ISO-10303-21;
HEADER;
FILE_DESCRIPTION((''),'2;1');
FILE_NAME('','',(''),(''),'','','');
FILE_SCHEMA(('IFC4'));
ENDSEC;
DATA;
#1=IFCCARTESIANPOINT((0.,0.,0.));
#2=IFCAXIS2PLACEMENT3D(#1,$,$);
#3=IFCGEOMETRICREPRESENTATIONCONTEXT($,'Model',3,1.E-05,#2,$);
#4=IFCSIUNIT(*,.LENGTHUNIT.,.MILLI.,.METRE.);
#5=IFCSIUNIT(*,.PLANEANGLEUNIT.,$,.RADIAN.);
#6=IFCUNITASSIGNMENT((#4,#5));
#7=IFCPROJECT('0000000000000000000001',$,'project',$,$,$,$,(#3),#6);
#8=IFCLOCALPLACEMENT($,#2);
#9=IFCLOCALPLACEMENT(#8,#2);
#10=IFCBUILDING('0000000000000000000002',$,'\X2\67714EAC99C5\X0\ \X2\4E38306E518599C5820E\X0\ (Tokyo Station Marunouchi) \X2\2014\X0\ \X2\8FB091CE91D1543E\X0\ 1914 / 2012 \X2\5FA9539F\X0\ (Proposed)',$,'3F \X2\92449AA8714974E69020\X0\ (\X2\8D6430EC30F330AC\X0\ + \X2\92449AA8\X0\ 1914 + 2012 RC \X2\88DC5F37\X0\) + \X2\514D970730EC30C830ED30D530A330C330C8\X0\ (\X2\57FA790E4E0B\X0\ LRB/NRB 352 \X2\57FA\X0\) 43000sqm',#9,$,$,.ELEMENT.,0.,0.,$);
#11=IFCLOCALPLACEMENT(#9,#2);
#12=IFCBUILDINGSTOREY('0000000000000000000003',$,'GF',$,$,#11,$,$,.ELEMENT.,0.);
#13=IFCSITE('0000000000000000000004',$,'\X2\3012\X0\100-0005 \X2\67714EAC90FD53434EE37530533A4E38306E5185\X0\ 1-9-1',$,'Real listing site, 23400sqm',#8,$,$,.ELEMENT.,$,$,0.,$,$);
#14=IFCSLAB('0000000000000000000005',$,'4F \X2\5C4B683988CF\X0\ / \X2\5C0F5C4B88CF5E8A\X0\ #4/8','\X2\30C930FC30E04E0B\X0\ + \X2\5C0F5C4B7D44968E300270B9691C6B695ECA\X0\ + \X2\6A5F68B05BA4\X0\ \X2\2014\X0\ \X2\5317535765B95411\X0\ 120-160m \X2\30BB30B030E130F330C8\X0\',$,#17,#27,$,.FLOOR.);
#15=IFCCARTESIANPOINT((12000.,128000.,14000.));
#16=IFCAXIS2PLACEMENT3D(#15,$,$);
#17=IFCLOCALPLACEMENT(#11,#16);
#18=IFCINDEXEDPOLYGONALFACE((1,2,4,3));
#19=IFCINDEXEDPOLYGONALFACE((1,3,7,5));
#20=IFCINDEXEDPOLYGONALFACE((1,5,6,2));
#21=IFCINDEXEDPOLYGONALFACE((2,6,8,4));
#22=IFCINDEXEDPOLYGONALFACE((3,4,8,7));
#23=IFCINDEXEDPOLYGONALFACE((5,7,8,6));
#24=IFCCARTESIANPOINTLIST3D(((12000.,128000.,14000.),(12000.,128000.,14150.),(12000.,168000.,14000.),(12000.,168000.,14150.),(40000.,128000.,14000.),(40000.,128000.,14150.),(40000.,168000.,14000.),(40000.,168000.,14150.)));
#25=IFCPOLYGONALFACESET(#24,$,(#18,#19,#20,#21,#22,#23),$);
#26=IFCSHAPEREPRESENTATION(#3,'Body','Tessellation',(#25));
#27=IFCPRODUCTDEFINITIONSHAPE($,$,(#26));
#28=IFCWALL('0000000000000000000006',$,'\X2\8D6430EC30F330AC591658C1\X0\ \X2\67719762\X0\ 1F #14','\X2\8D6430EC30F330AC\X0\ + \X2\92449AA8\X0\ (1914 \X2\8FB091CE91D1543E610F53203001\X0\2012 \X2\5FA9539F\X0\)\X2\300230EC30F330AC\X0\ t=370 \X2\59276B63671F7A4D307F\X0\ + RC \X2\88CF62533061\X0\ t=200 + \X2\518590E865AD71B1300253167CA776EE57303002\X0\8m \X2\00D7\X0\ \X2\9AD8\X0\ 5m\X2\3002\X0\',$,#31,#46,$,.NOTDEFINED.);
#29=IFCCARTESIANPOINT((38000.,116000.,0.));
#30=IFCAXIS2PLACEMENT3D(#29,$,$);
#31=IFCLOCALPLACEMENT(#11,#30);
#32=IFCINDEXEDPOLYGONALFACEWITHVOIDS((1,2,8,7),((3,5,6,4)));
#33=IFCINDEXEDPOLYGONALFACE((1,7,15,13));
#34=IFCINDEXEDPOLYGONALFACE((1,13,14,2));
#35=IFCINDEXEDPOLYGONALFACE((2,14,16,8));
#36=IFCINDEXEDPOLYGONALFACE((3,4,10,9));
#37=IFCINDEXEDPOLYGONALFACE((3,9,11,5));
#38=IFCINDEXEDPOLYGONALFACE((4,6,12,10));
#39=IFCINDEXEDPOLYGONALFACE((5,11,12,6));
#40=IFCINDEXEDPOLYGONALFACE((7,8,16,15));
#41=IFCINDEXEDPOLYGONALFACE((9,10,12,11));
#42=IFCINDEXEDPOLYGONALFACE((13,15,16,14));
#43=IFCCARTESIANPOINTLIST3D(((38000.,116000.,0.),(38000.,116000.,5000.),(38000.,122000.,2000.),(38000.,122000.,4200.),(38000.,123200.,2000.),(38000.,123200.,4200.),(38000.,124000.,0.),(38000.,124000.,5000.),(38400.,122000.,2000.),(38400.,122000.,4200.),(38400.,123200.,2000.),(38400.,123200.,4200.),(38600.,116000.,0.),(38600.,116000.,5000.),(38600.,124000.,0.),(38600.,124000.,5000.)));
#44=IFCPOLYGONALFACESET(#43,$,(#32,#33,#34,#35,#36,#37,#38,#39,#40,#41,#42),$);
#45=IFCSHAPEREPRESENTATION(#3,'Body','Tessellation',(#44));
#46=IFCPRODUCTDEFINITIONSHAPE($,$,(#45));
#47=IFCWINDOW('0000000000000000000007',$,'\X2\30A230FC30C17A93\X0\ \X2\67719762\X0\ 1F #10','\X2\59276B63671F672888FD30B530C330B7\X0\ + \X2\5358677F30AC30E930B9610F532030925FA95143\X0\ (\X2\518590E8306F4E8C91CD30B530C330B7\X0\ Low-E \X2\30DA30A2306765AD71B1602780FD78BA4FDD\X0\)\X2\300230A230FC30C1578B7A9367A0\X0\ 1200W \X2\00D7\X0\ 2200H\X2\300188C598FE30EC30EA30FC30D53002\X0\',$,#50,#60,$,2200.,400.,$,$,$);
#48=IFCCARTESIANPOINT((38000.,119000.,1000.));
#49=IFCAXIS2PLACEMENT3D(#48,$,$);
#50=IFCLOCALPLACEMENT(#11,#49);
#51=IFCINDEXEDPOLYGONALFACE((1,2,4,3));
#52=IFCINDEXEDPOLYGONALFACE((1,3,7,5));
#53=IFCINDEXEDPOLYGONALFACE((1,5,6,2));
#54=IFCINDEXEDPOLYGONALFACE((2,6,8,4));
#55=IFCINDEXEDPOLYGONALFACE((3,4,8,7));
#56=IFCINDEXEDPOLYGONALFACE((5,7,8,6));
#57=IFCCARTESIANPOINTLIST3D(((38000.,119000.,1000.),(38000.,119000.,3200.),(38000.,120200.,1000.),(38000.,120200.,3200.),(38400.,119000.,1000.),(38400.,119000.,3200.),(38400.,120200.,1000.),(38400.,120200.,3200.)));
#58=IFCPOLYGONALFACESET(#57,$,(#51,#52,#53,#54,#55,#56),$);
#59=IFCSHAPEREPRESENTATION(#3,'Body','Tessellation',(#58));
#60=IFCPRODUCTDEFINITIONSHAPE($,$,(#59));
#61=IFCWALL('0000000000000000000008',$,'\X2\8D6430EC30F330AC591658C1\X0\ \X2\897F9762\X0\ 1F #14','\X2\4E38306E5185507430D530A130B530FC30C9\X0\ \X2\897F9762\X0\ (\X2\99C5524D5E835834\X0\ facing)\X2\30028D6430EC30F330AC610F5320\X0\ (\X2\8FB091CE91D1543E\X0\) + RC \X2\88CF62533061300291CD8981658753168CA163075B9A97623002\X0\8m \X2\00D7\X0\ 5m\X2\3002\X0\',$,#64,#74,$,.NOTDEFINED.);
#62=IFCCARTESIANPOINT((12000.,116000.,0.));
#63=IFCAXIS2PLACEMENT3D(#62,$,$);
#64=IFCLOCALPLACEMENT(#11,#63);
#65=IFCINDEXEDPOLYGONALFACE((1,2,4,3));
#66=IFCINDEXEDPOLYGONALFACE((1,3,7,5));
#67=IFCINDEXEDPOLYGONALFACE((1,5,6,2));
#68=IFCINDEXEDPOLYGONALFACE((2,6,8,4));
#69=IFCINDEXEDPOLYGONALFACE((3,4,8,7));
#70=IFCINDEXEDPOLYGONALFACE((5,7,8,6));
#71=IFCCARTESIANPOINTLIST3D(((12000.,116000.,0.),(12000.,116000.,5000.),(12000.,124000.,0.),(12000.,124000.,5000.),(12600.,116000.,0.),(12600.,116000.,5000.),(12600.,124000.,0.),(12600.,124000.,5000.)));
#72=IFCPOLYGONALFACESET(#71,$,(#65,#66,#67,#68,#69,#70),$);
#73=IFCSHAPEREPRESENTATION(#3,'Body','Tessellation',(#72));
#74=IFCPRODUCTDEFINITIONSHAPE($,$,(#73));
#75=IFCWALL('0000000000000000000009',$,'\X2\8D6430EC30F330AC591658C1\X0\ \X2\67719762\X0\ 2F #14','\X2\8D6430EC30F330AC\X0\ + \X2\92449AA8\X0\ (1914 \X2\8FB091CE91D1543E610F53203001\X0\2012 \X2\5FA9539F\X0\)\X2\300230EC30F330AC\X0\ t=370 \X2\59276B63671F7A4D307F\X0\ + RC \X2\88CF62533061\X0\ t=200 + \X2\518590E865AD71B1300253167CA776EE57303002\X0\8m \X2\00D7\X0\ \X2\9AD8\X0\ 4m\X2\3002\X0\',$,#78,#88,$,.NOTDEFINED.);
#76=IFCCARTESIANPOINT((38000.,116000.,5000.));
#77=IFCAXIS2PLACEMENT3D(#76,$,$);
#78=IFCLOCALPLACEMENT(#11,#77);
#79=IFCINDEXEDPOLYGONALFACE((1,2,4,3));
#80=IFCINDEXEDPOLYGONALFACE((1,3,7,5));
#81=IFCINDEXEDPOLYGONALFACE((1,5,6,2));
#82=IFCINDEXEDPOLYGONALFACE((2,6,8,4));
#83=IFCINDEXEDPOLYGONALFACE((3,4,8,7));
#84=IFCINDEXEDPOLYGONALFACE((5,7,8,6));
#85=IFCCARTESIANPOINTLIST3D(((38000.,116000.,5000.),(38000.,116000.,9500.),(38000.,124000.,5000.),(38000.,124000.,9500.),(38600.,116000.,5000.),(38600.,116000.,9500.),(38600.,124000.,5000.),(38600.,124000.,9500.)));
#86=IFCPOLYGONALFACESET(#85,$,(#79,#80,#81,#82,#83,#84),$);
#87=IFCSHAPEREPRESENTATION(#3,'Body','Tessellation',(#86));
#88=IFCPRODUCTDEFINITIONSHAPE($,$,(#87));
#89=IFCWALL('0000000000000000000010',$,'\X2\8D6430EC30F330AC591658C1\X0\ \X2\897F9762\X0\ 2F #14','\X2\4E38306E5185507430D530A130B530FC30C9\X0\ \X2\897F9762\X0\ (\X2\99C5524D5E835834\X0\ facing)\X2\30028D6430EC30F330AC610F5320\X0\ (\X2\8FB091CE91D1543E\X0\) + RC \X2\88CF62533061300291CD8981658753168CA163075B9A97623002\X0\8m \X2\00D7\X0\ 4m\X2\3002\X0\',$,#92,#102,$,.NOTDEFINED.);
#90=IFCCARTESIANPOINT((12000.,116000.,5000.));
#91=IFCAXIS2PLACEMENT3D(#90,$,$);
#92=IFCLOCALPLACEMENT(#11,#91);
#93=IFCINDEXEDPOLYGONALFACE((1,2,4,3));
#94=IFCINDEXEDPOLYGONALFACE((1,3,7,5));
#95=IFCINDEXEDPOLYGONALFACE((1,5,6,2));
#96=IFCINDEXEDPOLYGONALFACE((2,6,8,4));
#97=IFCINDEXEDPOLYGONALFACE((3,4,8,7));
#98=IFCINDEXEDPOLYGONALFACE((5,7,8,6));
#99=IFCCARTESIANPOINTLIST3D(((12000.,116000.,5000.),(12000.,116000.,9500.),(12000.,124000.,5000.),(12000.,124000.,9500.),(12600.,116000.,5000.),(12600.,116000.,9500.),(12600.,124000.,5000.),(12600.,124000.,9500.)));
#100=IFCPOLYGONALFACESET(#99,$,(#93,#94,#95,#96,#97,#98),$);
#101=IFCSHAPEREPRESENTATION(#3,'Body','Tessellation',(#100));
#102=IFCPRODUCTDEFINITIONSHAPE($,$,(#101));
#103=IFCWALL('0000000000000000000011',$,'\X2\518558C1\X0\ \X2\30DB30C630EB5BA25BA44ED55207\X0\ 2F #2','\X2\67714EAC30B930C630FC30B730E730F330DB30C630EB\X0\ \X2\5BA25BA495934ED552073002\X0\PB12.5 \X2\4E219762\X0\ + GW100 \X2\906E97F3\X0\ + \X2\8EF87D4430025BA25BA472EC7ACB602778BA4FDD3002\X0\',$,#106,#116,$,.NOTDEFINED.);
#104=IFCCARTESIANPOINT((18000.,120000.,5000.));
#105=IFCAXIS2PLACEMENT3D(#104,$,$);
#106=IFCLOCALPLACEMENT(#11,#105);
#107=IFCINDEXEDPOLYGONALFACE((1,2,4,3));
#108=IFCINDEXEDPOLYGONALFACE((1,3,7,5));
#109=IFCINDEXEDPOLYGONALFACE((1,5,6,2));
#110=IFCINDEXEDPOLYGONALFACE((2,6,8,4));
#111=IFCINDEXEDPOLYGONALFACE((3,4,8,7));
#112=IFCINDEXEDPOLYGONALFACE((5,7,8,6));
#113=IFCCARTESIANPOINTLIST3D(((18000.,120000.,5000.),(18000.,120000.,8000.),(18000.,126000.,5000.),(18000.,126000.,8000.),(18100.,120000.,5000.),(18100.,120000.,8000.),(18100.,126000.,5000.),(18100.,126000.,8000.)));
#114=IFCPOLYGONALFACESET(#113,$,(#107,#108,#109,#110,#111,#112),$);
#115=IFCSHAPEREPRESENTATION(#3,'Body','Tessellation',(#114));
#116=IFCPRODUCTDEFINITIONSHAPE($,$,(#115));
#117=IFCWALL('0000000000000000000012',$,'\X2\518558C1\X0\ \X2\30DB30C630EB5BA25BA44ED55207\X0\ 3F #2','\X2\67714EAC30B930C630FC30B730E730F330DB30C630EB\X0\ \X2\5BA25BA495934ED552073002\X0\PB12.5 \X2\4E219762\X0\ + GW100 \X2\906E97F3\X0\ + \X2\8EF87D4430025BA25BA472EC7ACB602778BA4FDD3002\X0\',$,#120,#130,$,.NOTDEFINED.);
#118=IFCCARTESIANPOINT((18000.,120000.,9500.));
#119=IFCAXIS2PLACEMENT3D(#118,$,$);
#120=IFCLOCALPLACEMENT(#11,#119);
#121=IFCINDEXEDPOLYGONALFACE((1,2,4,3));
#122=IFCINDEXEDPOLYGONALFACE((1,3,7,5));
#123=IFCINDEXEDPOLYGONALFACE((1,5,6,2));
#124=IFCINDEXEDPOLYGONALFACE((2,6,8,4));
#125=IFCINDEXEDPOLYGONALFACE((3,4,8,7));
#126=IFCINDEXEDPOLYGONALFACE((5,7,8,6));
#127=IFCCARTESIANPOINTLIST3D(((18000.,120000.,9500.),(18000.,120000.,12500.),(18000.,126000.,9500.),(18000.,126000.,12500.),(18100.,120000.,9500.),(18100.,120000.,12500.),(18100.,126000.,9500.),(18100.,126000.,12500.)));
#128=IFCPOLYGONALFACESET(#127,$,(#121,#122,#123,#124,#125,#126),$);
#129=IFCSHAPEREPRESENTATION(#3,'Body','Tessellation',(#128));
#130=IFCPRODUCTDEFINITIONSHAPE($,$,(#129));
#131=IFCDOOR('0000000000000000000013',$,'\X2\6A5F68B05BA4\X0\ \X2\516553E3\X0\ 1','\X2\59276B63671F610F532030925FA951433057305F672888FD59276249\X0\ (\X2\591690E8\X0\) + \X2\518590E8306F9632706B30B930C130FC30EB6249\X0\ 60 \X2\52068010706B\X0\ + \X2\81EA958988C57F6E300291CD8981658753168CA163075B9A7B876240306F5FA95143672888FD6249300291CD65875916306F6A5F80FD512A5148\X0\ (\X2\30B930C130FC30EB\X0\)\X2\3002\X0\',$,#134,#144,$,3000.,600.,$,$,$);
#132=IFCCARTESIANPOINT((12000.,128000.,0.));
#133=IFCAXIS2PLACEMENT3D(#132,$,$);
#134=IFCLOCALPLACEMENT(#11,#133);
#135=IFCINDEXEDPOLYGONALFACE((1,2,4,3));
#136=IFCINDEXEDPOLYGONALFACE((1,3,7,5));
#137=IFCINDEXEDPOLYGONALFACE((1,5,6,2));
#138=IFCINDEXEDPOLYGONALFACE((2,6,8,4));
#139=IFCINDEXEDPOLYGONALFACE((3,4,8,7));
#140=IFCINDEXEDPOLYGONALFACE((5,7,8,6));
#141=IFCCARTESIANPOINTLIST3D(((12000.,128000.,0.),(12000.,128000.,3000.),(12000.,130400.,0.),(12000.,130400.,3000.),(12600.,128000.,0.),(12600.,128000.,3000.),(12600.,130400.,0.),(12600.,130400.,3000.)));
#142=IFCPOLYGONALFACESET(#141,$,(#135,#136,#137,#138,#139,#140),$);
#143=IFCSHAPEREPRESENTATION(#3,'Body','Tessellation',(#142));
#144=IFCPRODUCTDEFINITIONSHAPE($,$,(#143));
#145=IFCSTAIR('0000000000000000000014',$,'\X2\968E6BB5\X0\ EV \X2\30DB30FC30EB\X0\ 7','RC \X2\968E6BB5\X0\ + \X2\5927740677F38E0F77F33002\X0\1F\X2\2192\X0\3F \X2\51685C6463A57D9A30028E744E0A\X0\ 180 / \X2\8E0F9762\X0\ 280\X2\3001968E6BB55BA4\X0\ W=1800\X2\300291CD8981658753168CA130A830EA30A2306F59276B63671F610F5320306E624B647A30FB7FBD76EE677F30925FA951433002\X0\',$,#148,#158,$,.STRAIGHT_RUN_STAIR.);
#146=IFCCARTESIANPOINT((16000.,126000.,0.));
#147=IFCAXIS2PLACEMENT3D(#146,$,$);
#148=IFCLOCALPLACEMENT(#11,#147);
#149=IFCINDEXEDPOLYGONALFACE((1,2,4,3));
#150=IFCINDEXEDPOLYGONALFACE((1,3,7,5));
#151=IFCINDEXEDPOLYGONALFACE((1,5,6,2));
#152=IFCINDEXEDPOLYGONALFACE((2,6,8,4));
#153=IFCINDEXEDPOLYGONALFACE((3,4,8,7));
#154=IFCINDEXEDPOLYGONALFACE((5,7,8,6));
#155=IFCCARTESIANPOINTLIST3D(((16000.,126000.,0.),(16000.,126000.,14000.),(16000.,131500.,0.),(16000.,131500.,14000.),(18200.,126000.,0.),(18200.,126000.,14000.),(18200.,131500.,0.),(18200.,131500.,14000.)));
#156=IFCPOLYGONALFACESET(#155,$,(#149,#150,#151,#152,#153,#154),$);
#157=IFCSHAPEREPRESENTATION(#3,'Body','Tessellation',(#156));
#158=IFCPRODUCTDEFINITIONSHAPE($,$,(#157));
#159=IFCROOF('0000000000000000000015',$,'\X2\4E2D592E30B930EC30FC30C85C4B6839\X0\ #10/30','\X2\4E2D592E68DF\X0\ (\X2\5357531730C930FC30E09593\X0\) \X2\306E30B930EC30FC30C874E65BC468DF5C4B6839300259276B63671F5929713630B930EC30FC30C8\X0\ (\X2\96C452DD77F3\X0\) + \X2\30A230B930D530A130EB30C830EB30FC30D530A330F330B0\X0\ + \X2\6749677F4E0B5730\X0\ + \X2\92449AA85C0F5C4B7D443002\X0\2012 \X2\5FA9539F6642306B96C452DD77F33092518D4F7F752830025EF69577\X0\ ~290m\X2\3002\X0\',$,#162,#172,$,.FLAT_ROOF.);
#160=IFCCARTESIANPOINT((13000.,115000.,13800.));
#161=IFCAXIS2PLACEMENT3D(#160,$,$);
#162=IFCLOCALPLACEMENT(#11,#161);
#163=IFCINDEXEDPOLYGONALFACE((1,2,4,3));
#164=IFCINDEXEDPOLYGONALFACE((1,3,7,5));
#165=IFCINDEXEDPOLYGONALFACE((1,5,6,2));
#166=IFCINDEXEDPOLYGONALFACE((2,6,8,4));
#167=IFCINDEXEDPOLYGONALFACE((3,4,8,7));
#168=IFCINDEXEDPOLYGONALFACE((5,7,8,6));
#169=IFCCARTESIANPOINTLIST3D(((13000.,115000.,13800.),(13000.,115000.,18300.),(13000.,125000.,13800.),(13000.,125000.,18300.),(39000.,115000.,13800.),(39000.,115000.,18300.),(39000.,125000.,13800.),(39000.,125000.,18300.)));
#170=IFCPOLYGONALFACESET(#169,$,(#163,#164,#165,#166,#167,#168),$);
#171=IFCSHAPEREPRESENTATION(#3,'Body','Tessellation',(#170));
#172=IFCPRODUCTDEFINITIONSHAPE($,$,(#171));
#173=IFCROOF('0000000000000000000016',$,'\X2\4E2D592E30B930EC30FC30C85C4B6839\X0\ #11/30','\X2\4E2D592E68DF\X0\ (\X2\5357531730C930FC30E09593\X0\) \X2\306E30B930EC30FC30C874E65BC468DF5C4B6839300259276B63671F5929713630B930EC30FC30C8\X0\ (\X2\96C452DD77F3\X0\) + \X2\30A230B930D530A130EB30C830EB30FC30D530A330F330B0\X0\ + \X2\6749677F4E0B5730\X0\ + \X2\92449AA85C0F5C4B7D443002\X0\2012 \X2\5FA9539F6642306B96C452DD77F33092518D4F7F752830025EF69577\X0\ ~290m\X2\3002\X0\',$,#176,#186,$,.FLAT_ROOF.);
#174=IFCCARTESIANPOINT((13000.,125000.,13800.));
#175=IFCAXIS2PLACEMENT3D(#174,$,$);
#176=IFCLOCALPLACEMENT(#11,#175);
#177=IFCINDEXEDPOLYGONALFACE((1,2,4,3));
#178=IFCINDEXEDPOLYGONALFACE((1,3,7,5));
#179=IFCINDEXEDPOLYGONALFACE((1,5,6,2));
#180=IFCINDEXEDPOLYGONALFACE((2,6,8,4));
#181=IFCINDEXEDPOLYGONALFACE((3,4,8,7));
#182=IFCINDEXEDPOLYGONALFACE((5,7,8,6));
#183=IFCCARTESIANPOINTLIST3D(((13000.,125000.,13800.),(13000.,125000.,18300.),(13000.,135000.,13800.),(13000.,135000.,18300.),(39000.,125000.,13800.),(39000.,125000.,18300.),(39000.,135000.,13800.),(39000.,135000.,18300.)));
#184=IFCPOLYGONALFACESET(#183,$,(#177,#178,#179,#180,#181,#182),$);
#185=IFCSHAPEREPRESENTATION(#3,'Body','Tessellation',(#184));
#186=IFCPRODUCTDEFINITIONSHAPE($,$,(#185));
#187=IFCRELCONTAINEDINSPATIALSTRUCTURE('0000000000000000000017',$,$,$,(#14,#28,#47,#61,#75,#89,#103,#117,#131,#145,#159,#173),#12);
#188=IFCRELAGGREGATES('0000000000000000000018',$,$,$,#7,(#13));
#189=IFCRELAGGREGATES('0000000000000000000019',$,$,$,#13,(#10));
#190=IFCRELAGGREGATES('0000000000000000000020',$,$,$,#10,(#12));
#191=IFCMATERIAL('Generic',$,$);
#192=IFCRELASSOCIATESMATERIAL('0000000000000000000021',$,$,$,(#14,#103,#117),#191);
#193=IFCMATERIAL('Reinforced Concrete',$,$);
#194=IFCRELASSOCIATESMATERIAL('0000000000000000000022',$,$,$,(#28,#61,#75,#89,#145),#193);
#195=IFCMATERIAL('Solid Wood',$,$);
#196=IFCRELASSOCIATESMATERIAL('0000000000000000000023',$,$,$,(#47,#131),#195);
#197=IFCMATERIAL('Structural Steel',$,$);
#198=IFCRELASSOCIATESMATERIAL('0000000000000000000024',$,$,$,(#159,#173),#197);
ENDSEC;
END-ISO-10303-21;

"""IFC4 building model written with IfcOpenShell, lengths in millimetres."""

from ifc_helpers import new_model, si_unit, frame, frame_2d, origin, place, context, project, spatial, rectangle, extrude, material, element, fill, save


model = new_model("IFC4")

# Units and contexts
model_context = context("Model", 3, precision=1e-05, world=origin())
ifc_project = project(units=[si_unit("LENGTHUNIT", "METRE", prefix="MILLI"), si_unit("PLANEANGLEUNIT", "RADIAN")], contexts=[model_context])

# Site, building, storey
site_placement = place(None, origin())
site = spatial("IfcSite", under=ifc_project, at=site_placement, Name="〒100-0005 東京都千代田区丸の内 1-9-1", ObjectType="Real listing site, 23400sqm", CompositionType="ELEMENT", RefElevation=0.0)
building_placement = place(site_placement, origin())
building = spatial("IfcBuilding", under=site, at=building_placement, Name="東京駅 丸の内駅舎 (Tokyo Station Marunouchi) — 辰野金吾 1914 / 2012 復原 (Proposed)", ObjectType="3F 鉄骨煉瓦造 (赤レンガ + 鉄骨 1914 + 2012 RC 補強) + 免震レトロフィット (基礎下 LRB/NRB 352 基) 43000sqm", CompositionType="ELEMENT", ElevationOfRefHeight=0.0, ElevationOfTerrain=0.0)
storey_placement = place(building_placement, origin())
storey = spatial("IfcBuildingStorey", under=building, at=storey_placement, Name="GF", CompositionType="ELEMENT", Elevation=0.0)

# Shared definitions
ifc_material_1 = material(Name="Reinforced Concrete")

# Shared definitions
ifc_material_2 = material(Name="Structural Steel")

# Slab
ifc_material_3 = material(Name="Generic")
slab_1_placement = place(storey_placement, frame((12000.0, 128000.0, 14000.0)))
element("IfcSlab", 1, at=slab_1_placement, inside=storey, material=ifc_material_3, Name="4F 屋根裏 / 小屋裏床 #4/8", Description="ドーム下 + 小屋組階。点検歩廊 + 機械室 — 北南方向 120-160m セグメント", PredefinedType="FLOOR", context=model_context, shape_type="SweptSolid", body=[
    extrude(rectangle(XDim=28000.0, YDim=40000.0, at=frame_2d((14000.0, 20000.0))), frame((12000.0, 128000.0, 14000.0)), (0.0, 0.0, 1.0), 150.0),
])

# Wall, opening, window
wall_1_placement = place(storey_placement, frame((38000.0, 116000.0, 0.0)))
wall_1 = element("IfcWall", 2, at=wall_1_placement, inside=storey, material=ifc_material_1, Name="赤レンガ外壁 東面 1F #14", Description="赤レンガ + 鉄骨 (1914 辰野金吾意匠、2012 復原)。レンガ t=370 大正期積み + RC 裏打ち t=200 + 内部断熱。化粧目地。8m × 高 5m。", PredefinedType="NOTDEFINED", context=model_context, shape_type="SweptSolid", body=[
    extrude(rectangle(XDim=600.0, YDim=8000.0, at=frame_2d((300.0, 4000.0))), frame((38000.0, 116000.0, 0.0)), (0.0, 0.0, 1.0), 5000.0),
])
opening_placement = place(storey_placement, frame((38000.0, 119000.0, 1000.0)))
opening = element("IfcOpeningElement", 3, at=opening_placement, cuts=wall_1, PredefinedType="NOTDEFINED", context=model_context, shape_type="SweptSolid", body=[
    extrude(rectangle(XDim=400.0, YDim=1200.0, at=frame_2d((200.0, 600.0))), frame((38000.0, 119000.0, 1000.0)), (0.0, 0.0, 1.0), 2200.0),
])
ifc_material_4 = material(Name="Solid Wood")
window_placement = place(storey_placement, frame((38000.0, 119000.0, 1000.0)))
window = element("IfcWindow", 4, at=window_placement, inside=storey, material=ifc_material_4, Name="アーチ窓 東面 1F #10", Description="大正期木製サッシ + 単板ガラス意匠を復元 (内部は二重サッシ Low-E ペアで断熱性能確保)。アーチ型窓枠 1200W × 2200H、装飾レリーフ。", OverallHeight=2200.0, OverallWidth=400.0, context=model_context, shape_type="SweptSolid", body=[
    extrude(rectangle(XDim=400.0, YDim=1200.0, at=frame_2d((200.0, 600.0))), frame((38000.0, 119000.0, 1000.0)), (0.0, 0.0, 1.0), 2200.0),
])
fill(opening, window)

# Walls
wall_2_placement = place(storey_placement, frame((12000.0, 116000.0, 0.0)))
element("IfcWall", 5, at=wall_2_placement, inside=storey, material=ifc_material_1, Name="赤レンガ外壁 西面 1F #14", Description="丸の内側ファサード 西面 (駅前広場 facing)。赤レンガ意匠 (辰野金吾) + RC 裏打ち。重要文化財指定面。8m × 5m。", PredefinedType="NOTDEFINED", context=model_context, shape_type="SweptSolid", body=[
    extrude(rectangle(XDim=600.0, YDim=8000.0, at=frame_2d((300.0, 4000.0))), frame((12000.0, 116000.0, 0.0)), (0.0, 0.0, 1.0), 5000.0),
])
wall_3_placement = place(storey_placement, frame((38000.0, 116000.0, 5000.0)))
element("IfcWall", 6, at=wall_3_placement, inside=storey, material=ifc_material_1, Name="赤レンガ外壁 東面 2F #14", Description="赤レンガ + 鉄骨 (1914 辰野金吾意匠、2012 復原)。レンガ t=370 大正期積み + RC 裏打ち t=200 + 内部断熱。化粧目地。8m × 高 4m。", PredefinedType="NOTDEFINED", context=model_context, shape_type="SweptSolid", body=[
    extrude(rectangle(XDim=600.0, YDim=8000.0, at=frame_2d((300.0, 4000.0))), frame((38000.0, 116000.0, 5000.0)), (0.0, 0.0, 1.0), 4500.0),
])
wall_4_placement = place(storey_placement, frame((12000.0, 116000.0, 5000.0)))
element("IfcWall", 7, at=wall_4_placement, inside=storey, material=ifc_material_1, Name="赤レンガ外壁 西面 2F #14", Description="丸の内側ファサード 西面 (駅前広場 facing)。赤レンガ意匠 (辰野金吾) + RC 裏打ち。重要文化財指定面。8m × 4m。", PredefinedType="NOTDEFINED", context=model_context, shape_type="SweptSolid", body=[
    extrude(rectangle(XDim=600.0, YDim=8000.0, at=frame_2d((300.0, 4000.0))), frame((12000.0, 116000.0, 5000.0)), (0.0, 0.0, 1.0), 4500.0),
])
wall_5_placement = place(storey_placement, frame((18000.0, 120000.0, 5000.0)))
element("IfcWall", 8, at=wall_5_placement, inside=storey, material=ifc_material_3, Name="内壁 ホテル客室仕切 2F #2", Description="東京ステーションホテル 客室間仕切。PB12.5 両面 + GW100 遮音 + 軸組。客室独立性確保。", PredefinedType="NOTDEFINED", context=model_context, shape_type="SweptSolid", body=[
    extrude(rectangle(XDim=100.0, YDim=6000.0, at=frame_2d((50.0, 3000.0))), frame((18000.0, 120000.0, 5000.0)), (0.0, 0.0, 1.0), 3000.0),
])
wall_6_placement = place(storey_placement, frame((18000.0, 120000.0, 9500.0)))
element("IfcWall", 9, at=wall_6_placement, inside=storey, material=ifc_material_3, Name="内壁 ホテル客室仕切 3F #2", Description="東京ステーションホテル 客室間仕切。PB12.5 両面 + GW100 遮音 + 軸組。客室独立性確保。", PredefinedType="NOTDEFINED", context=model_context, shape_type="SweptSolid", body=[
    extrude(rectangle(XDim=100.0, YDim=6000.0, at=frame_2d((50.0, 3000.0))), frame((18000.0, 120000.0, 9500.0)), (0.0, 0.0, 1.0), 3000.0),
])

# Door
door_placement = place(storey_placement, frame((12000.0, 128000.0, 0.0)))
element("IfcDoor", 10, at=door_placement, inside=storey, material=ifc_material_4, Name="機械室 入口 1", Description="大正期意匠を復元した木製大扉 (外部) + 内部は防火スチール扉 60 分耐火 + 自閉装置。重要文化財指定箇所は復元木製扉。重文外は機能優先 (スチール)。", OverallHeight=3000.0, OverallWidth=600.0, context=model_context, shape_type="SweptSolid", body=[
    extrude(rectangle(XDim=600.0, YDim=2400.0, at=frame_2d((300.0, 1200.0))), frame((12000.0, 128000.0, 0.0)), (0.0, 0.0, 1.0), 3000.0),
])

# Stair
stair_placement = place(storey_placement, frame((16000.0, 126000.0, 0.0)))
element("IfcStair", 11, at=stair_placement, inside=storey, material=ifc_material_1, Name="階段 EV ホール 7", Description="RC 階段 + 大理石踏石。1F→3F 全層接続。蹴上 180 / 踏面 280、階段室 W=1800。重要文化財エリアは大正期意匠の手摺・羽目板を復元。", PredefinedType="STRAIGHT_RUN_STAIR", context=model_context, shape_type="SweptSolid", body=[
    extrude(rectangle(XDim=2200.0, YDim=5500.0, at=frame_2d((1100.0, 2750.0))), frame((16000.0, 126000.0, 0.0)), (0.0, 0.0, 1.0), 14000.0),
])

# Roofs
roof_1_placement = place(storey_placement, frame((13000.0, 115000.0, 13800.0)))
element("IfcRoof", 12, at=roof_1_placement, inside=storey, material=ifc_material_2, Name="中央スレート屋根 #10/30", Description="中央棟 (南北ドーム間) のスレート瓦寄棟屋根。大正期天然スレート (雄勝石) + アスファルトルーフィング + 杉板下地 + 鉄骨小屋組。2012 復原時に雄勝石を再使用。延長 ~290m。", PredefinedType="FLAT_ROOF", context=model_context, shape_type="SweptSolid", body=[
    extrude(rectangle(XDim=26000.0, YDim=10000.0, at=frame_2d((13000.0, 5000.0))), frame((13000.0, 115000.0, 13800.0)), (0.0, 0.0, 1.0), 4500.0),
])
roof_2_placement = place(storey_placement, frame((13000.0, 125000.0, 13800.0)))
element("IfcRoof", 13, at=roof_2_placement, inside=storey, material=ifc_material_2, Name="中央スレート屋根 #11/30", Description="中央棟 (南北ドーム間) のスレート瓦寄棟屋根。大正期天然スレート (雄勝石) + アスファルトルーフィング + 杉板下地 + 鉄骨小屋組。2012 復原時に雄勝石を再使用。延長 ~290m。", PredefinedType="FLAT_ROOF", context=model_context, shape_type="SweptSolid", body=[
    extrude(rectangle(XDim=26000.0, YDim=10000.0, at=frame_2d((13000.0, 5000.0))), frame((13000.0, 125000.0, 13800.0)), (0.0, 0.0, 1.0), 4500.0),
])

save(model, "model.ifc")
